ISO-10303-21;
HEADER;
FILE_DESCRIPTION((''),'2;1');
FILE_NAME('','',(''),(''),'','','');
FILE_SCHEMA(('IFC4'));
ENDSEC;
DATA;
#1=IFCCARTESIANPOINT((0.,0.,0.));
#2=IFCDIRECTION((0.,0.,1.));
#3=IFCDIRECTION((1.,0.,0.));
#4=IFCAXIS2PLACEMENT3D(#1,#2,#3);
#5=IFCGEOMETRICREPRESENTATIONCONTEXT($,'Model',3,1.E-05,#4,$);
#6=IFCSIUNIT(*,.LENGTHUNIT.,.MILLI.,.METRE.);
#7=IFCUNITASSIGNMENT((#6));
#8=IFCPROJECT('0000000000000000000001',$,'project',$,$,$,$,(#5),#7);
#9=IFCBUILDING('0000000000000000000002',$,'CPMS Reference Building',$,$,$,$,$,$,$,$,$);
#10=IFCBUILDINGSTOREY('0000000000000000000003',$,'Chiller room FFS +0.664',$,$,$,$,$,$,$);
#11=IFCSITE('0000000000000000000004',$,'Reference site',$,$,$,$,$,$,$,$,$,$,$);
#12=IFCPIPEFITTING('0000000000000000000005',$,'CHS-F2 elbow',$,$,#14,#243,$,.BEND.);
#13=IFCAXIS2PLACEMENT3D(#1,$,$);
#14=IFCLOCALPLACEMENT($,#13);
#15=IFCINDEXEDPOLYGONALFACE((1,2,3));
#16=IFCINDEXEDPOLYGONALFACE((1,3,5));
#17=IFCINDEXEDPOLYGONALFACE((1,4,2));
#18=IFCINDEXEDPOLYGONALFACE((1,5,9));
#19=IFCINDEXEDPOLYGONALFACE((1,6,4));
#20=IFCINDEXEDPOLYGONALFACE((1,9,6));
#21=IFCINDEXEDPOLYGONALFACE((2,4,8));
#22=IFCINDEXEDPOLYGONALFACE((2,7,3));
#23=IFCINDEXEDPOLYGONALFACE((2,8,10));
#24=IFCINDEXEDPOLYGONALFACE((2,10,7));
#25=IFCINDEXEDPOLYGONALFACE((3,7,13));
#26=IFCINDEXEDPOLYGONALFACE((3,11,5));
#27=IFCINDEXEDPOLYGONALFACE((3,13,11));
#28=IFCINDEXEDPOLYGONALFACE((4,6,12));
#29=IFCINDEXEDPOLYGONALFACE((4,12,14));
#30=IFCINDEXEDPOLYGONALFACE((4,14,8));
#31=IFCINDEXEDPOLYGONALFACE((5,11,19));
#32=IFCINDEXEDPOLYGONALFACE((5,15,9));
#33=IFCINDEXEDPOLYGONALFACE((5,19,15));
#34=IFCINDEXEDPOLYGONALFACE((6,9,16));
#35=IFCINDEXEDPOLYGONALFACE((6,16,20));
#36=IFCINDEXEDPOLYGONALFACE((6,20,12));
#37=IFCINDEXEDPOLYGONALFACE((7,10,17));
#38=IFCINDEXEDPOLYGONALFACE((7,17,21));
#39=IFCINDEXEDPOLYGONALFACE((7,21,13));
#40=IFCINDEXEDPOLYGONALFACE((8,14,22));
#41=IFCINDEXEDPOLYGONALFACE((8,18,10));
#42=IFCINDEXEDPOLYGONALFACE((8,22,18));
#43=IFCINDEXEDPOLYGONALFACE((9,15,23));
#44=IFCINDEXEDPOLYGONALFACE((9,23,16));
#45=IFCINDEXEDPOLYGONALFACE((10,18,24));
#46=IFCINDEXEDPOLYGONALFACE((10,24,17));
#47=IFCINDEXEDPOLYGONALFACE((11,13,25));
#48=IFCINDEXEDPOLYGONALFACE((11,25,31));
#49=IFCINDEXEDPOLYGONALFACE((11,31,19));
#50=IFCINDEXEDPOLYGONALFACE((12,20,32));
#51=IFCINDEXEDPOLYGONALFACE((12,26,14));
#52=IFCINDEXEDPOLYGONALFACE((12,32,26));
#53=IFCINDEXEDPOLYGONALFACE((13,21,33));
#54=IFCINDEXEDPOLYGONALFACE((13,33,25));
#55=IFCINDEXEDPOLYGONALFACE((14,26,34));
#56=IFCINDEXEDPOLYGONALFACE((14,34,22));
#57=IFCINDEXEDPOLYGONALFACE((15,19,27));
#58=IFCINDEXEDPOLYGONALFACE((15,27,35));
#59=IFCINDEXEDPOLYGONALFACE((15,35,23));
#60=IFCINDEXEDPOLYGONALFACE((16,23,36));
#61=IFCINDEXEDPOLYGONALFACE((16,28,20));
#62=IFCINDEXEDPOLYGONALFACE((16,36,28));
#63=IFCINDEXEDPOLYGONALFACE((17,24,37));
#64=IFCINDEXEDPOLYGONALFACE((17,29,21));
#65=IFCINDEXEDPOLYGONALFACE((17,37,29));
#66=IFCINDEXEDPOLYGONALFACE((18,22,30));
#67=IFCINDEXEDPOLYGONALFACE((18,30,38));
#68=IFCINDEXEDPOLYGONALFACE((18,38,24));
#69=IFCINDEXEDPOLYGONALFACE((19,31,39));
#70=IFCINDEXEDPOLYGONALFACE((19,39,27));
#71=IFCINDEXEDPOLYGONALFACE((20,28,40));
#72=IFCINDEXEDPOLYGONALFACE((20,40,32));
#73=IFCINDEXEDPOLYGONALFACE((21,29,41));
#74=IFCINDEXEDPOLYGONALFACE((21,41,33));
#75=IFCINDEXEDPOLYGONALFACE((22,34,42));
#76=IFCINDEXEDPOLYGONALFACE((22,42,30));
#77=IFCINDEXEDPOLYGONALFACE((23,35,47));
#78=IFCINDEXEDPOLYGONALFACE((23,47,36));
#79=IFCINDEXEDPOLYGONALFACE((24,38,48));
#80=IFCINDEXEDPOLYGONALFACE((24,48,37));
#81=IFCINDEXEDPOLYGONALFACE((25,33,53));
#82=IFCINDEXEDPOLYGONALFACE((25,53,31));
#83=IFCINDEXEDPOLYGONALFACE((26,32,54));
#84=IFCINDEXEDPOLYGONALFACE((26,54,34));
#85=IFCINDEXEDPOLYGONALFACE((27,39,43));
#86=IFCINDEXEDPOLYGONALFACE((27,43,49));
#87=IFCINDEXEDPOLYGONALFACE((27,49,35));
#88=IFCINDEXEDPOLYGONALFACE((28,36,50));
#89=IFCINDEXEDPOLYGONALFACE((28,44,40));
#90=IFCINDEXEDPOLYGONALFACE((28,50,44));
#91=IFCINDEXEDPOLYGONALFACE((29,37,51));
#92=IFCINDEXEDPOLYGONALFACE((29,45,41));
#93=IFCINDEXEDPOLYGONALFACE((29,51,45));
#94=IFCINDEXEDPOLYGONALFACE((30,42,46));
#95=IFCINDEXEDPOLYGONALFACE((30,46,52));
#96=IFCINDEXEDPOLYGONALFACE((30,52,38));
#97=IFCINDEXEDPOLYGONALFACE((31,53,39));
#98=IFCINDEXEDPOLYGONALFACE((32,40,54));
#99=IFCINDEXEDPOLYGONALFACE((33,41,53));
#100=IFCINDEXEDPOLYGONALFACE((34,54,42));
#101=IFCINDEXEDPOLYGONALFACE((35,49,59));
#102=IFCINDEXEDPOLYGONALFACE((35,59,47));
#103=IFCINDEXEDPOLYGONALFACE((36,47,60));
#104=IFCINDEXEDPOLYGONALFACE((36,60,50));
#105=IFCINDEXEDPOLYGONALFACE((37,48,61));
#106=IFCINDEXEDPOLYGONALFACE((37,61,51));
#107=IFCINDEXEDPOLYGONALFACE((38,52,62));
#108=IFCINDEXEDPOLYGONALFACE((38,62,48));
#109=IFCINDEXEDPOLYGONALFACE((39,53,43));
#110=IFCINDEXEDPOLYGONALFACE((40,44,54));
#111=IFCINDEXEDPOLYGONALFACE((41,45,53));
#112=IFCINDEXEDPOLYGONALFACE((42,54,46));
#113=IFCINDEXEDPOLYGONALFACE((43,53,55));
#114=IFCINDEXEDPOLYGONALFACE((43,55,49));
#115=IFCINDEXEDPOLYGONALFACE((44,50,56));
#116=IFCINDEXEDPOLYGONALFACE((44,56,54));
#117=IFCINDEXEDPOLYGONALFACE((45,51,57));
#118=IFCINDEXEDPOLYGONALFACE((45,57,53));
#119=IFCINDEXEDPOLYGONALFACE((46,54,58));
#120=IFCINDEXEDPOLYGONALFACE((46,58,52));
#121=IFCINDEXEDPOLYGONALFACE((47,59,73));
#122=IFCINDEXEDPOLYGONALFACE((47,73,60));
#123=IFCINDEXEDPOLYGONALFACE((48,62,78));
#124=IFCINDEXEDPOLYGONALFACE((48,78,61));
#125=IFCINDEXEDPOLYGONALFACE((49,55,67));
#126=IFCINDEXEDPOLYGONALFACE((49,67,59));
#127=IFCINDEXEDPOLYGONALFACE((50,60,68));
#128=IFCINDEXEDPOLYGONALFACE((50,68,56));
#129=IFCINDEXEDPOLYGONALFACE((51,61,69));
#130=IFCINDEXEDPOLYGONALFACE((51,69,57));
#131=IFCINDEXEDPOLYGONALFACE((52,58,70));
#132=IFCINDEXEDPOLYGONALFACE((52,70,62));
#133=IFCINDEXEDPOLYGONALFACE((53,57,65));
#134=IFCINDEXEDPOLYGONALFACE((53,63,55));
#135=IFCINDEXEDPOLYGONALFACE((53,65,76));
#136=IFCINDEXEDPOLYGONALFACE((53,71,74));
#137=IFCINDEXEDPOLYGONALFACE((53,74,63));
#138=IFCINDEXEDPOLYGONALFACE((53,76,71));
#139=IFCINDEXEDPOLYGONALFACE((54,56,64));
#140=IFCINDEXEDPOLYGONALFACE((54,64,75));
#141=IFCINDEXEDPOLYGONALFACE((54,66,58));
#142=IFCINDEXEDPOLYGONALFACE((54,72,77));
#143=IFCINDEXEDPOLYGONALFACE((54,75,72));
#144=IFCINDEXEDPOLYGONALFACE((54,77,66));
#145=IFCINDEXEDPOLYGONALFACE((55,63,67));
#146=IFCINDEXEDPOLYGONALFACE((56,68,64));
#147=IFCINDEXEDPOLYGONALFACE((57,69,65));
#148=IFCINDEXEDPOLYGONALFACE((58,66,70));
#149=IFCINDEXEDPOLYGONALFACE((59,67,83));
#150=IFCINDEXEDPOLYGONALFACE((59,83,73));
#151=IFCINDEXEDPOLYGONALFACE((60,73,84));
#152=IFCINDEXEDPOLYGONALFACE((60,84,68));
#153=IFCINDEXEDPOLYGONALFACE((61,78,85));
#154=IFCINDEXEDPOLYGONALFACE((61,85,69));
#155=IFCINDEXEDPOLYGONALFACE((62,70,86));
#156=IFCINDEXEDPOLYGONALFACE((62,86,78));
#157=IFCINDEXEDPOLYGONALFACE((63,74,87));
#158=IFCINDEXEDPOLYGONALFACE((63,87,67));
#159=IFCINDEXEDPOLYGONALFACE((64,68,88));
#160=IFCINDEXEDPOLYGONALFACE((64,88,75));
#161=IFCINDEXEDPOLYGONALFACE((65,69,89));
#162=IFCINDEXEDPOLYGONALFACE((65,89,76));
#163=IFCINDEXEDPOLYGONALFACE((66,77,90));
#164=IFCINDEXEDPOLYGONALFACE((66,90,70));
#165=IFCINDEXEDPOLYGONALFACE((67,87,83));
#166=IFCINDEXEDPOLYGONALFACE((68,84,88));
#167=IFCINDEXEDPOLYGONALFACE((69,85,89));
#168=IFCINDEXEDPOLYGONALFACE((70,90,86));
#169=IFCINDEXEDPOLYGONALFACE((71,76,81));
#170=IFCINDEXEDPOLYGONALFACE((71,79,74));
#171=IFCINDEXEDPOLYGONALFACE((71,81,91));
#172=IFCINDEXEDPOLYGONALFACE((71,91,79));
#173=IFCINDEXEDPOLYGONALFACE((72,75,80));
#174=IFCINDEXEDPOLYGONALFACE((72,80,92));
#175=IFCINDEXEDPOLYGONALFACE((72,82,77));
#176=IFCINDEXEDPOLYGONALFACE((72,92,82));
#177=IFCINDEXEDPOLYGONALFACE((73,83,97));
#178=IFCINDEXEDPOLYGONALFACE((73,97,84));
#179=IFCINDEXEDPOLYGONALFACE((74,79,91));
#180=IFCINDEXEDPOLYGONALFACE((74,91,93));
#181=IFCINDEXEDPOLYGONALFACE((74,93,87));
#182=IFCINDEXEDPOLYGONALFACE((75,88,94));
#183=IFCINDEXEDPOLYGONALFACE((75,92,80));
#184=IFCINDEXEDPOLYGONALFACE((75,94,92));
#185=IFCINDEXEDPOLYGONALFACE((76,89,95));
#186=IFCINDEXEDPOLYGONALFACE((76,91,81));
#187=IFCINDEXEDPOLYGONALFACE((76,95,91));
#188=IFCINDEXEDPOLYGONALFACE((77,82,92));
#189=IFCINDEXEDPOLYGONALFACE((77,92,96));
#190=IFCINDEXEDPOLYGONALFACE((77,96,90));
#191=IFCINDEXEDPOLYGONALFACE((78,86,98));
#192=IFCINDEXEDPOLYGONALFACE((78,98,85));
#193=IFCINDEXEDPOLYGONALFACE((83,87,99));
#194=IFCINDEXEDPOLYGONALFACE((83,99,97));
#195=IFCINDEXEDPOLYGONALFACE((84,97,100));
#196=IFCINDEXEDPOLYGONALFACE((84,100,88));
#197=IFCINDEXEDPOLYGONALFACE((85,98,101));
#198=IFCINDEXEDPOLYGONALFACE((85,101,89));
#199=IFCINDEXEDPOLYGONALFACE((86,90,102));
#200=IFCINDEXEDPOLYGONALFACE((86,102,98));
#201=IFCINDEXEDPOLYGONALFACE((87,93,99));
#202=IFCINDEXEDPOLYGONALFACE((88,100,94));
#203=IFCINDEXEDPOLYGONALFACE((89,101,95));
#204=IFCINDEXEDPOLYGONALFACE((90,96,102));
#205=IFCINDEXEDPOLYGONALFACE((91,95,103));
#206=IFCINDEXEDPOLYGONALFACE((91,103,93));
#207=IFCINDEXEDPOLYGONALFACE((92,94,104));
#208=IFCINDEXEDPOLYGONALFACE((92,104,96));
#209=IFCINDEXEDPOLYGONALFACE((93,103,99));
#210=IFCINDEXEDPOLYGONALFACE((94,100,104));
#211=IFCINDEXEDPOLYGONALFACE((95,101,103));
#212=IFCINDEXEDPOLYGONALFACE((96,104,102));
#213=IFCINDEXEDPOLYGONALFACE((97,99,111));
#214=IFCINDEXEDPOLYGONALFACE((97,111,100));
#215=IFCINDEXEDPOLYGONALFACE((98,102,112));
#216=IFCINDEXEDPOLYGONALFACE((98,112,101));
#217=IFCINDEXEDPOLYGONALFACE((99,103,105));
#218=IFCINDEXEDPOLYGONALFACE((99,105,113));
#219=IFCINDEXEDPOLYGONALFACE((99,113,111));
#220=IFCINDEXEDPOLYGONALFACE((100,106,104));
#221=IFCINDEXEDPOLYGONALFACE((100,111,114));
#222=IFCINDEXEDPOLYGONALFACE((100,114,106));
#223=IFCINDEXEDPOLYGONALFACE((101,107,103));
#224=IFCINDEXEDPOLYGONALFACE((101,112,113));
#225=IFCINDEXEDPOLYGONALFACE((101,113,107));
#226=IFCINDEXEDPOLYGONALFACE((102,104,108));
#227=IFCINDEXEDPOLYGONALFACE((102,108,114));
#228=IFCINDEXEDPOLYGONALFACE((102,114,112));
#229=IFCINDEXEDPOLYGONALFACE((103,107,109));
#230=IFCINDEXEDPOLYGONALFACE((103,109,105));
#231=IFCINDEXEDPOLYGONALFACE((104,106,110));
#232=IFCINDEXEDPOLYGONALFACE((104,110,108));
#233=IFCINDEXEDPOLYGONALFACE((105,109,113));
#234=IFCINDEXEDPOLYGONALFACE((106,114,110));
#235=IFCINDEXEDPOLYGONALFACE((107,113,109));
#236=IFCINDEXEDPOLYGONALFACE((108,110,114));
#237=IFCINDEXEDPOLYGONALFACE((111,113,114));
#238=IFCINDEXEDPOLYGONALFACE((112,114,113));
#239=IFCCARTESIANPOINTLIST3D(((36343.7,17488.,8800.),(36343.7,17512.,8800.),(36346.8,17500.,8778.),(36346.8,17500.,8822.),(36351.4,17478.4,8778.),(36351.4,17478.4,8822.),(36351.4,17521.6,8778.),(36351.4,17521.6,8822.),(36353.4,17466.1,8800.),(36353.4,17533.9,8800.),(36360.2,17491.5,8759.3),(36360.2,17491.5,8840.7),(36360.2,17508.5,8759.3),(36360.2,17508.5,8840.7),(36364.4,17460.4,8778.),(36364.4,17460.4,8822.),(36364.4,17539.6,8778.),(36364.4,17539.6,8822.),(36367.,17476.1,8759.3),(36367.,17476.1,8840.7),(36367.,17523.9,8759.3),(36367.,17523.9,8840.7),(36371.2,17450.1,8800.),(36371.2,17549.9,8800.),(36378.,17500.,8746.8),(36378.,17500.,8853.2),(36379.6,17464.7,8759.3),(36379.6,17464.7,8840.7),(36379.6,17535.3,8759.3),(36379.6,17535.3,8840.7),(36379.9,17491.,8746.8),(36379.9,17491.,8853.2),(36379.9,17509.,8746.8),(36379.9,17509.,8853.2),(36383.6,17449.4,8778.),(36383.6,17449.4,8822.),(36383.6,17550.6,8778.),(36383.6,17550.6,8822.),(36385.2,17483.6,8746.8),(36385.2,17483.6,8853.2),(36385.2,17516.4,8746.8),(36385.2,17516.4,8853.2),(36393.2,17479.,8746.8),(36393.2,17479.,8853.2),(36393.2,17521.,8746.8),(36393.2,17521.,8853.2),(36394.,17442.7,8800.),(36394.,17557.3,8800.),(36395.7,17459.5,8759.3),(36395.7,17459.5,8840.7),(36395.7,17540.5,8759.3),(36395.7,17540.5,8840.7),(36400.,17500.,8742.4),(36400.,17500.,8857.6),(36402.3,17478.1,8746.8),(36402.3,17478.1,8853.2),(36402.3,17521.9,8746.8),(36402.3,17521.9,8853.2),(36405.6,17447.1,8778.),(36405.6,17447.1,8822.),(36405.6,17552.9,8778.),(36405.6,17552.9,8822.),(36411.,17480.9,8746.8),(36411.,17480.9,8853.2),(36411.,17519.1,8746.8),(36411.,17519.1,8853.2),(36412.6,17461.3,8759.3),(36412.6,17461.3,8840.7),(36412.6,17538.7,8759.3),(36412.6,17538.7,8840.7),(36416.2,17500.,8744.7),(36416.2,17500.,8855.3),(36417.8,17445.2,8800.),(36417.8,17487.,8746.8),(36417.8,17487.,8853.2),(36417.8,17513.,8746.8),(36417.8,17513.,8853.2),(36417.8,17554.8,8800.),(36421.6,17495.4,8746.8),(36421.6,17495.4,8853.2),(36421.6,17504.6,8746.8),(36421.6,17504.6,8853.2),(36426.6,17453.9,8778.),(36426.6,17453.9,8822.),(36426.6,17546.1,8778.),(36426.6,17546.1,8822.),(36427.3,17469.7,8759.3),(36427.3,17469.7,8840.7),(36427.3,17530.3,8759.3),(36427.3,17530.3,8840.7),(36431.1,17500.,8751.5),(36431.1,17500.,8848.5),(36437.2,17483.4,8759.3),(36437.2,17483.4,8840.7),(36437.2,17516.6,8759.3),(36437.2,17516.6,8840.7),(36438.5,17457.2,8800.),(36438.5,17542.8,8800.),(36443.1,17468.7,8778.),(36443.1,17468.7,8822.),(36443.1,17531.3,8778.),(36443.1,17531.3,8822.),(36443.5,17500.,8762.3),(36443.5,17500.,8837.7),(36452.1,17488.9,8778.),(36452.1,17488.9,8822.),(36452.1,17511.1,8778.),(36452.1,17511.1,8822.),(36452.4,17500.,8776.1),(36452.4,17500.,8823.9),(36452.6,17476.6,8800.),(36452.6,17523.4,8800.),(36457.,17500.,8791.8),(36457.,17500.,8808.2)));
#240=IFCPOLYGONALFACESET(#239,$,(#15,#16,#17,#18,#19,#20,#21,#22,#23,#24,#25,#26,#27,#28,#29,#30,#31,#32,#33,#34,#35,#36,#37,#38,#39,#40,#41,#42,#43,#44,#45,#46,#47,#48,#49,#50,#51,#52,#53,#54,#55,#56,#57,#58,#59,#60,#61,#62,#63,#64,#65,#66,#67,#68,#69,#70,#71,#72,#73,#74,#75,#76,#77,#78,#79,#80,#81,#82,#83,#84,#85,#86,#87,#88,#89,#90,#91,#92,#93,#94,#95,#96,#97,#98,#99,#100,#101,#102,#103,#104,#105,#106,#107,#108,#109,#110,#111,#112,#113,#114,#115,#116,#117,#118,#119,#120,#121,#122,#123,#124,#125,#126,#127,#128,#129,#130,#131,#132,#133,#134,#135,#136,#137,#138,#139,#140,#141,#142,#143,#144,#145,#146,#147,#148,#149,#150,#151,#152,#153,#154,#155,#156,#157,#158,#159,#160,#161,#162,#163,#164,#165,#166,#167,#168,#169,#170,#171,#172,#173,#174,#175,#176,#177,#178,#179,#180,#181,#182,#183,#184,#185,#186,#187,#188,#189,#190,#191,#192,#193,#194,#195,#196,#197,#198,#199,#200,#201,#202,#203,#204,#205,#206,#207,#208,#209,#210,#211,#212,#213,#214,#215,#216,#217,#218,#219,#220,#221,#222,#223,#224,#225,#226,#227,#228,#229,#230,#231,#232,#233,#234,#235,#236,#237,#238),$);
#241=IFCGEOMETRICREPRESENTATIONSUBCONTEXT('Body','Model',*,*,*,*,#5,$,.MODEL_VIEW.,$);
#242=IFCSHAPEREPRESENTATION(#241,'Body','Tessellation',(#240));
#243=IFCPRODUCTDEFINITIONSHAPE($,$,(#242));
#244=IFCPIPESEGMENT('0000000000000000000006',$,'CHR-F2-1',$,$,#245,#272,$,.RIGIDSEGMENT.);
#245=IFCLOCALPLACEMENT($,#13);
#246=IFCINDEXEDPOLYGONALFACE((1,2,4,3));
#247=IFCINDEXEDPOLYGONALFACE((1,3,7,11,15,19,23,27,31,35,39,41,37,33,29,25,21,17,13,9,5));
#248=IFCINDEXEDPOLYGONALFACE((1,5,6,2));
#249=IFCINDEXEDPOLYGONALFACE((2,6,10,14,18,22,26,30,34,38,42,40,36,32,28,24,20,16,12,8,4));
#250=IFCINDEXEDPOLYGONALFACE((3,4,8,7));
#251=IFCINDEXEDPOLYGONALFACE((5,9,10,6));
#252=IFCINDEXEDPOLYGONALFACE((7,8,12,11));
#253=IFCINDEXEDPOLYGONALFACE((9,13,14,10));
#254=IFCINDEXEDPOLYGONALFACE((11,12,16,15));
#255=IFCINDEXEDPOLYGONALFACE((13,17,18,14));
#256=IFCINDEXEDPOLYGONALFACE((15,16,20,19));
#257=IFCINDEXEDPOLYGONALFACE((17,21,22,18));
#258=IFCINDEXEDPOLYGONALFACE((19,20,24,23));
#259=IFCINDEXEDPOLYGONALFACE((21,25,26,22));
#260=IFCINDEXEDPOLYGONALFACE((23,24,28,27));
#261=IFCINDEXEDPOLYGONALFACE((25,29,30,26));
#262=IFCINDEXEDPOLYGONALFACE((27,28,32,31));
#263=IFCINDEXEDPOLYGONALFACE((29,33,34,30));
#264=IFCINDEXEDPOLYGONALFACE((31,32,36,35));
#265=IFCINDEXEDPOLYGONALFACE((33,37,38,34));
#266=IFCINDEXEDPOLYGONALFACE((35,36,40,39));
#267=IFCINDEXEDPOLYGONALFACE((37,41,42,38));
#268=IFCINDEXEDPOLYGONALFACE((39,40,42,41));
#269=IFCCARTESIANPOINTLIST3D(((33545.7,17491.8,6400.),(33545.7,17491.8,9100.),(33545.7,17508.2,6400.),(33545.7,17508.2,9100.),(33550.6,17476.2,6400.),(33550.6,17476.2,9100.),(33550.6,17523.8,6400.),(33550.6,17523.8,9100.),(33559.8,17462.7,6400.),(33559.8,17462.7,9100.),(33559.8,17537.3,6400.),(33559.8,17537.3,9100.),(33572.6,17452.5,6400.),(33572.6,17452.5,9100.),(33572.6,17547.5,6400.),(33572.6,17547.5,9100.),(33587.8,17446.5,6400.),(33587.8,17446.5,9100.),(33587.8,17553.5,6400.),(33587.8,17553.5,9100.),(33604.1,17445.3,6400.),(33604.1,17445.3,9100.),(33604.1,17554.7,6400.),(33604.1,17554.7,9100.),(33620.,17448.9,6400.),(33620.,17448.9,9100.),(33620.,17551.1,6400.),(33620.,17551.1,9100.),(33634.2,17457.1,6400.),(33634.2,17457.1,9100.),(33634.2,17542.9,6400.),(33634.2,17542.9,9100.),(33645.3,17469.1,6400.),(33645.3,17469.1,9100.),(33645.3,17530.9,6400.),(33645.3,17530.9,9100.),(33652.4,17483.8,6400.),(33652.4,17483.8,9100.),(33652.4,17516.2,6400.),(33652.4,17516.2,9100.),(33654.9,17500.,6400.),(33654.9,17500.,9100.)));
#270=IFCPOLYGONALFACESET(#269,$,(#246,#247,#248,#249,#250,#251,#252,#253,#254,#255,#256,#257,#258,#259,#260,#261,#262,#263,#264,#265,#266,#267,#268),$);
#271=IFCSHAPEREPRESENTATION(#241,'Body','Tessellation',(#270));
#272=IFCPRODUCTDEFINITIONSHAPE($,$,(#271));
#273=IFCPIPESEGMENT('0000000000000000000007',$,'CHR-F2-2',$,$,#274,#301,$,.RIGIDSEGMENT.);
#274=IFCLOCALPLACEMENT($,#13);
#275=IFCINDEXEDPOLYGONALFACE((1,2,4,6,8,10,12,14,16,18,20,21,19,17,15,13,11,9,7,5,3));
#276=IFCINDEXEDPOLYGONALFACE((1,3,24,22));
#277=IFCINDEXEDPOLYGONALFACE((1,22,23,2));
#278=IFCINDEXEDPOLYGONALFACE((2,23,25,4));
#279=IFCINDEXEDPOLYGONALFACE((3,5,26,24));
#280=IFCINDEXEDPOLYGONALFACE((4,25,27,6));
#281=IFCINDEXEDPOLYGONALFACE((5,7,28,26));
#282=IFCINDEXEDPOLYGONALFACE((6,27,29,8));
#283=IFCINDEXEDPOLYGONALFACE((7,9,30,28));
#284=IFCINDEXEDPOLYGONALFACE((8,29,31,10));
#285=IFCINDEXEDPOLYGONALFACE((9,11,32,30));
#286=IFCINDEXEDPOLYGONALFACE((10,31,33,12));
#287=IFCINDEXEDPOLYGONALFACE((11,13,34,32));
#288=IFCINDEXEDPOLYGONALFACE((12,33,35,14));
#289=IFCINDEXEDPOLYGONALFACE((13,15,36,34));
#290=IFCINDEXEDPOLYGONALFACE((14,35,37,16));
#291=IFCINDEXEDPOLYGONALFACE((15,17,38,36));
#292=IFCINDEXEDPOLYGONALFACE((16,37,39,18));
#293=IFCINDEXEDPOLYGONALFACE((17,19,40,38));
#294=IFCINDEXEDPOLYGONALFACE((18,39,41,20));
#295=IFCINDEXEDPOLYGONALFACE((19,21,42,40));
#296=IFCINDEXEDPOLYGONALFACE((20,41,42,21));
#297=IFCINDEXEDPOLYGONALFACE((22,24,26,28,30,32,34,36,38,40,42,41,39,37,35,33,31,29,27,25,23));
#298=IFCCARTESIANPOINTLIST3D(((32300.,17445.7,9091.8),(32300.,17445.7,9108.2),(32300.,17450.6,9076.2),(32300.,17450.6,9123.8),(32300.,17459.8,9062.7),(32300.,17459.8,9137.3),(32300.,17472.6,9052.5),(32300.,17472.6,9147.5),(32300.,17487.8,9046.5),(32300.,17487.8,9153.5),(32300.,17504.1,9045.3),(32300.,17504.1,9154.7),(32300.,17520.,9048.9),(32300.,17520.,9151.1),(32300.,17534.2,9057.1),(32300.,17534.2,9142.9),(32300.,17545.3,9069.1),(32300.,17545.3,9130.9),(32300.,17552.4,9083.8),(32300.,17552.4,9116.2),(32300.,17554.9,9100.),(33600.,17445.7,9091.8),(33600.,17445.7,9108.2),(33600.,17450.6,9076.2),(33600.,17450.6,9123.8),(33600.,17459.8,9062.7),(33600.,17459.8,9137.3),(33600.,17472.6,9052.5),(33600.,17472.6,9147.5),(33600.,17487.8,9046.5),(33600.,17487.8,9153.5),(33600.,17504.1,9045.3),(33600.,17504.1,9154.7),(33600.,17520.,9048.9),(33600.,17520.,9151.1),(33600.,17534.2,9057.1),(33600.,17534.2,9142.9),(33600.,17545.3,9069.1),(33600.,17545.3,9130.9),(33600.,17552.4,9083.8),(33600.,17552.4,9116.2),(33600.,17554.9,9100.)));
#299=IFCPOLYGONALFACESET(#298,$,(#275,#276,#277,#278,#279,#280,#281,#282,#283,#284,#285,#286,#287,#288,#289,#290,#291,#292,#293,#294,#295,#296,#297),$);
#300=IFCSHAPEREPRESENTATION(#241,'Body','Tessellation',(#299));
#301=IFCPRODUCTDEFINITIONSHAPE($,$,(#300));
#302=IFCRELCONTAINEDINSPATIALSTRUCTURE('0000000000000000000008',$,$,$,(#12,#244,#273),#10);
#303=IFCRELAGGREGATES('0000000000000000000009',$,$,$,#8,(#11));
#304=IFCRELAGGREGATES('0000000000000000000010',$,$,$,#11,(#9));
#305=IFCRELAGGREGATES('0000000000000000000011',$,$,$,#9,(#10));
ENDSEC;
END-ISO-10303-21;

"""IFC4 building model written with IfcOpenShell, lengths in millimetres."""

from ifc_helpers import new_model, entity, si_unit, frame, origin_with_axes, origin_2d, place, context, subcontext, project, spatial, circle_curve, outline, extrude, element, save


model = new_model("IFC4")

# Units and contexts
model_context = context("Model", 3, precision=1e-05, world=origin_with_axes())
body_context = subcontext(model_context, "Body", "Model", "MODEL_VIEW")
ifc_project = project(units=[si_unit("LENGTHUNIT", "METRE", prefix="MILLI")], contexts=[model_context])

# Site, building, storey
site = spatial("IfcSite", under=ifc_project, Name="Reference site")
building = spatial("IfcBuilding", under=site, Name="CPMS Reference Building")
storey = spatial("IfcBuildingStorey", under=building, Name="Chiller room FFS +0.664")

# Pipe fitting
pipe_fitting_1_placement = place(None, origin_with_axes())
element("IfcPipeFitting", 1, at=pipe_fitting_1_placement, inside=storey, Name="CHS-F2 elbow", PredefinedType="BEND", context=body_context, shape_type="CSG", body=[
    entity("IfcSphere", entity("IfcAxis2Placement3D", entity("IfcCartesianPoint", [36400.0, 17500.0, 8800.0]), entity("IfcDirection", [0.0, 0.0, 1.0]), entity("IfcDirection", [1.0, 0.0, 0.0])), 57.6),
])

# Pipe segments
pipe_segment_1_placement = place(None, origin_with_axes())
element("IfcPipeSegment", 2, at=pipe_segment_1_placement, inside=storey, Name="CHR-F2-1", PredefinedType="RIGIDSEGMENT", context=body_context, shape_type="SweptSolid", body=[
    extrude(outline(circle_curve(origin_2d(), 54.9)), frame((33600.0, 17500.0, 6400.0), z_axis=(0.0, 0.0, 1.0), x_axis=(1.0, 0.0, 0.0)), (0.0, 0.0, 1.0), 2700.0),
])
pipe_segment_2_placement = place(None, origin_with_axes())
element("IfcPipeSegment", 3, at=pipe_segment_2_placement, inside=storey, Name="CHR-F2-2", PredefinedType="RIGIDSEGMENT", context=body_context, shape_type="SweptSolid", body=[
    extrude(outline(circle_curve(origin_2d(), 54.9)), frame((33600.0, 17500.0, 9100.0), z_axis=(-1.0, 0.0, 0.0), x_axis=(0.0, 1.0, 0.0)), (0.0, 0.0, 1.0), 1300.0),
])

save(model, "model.ifc")
